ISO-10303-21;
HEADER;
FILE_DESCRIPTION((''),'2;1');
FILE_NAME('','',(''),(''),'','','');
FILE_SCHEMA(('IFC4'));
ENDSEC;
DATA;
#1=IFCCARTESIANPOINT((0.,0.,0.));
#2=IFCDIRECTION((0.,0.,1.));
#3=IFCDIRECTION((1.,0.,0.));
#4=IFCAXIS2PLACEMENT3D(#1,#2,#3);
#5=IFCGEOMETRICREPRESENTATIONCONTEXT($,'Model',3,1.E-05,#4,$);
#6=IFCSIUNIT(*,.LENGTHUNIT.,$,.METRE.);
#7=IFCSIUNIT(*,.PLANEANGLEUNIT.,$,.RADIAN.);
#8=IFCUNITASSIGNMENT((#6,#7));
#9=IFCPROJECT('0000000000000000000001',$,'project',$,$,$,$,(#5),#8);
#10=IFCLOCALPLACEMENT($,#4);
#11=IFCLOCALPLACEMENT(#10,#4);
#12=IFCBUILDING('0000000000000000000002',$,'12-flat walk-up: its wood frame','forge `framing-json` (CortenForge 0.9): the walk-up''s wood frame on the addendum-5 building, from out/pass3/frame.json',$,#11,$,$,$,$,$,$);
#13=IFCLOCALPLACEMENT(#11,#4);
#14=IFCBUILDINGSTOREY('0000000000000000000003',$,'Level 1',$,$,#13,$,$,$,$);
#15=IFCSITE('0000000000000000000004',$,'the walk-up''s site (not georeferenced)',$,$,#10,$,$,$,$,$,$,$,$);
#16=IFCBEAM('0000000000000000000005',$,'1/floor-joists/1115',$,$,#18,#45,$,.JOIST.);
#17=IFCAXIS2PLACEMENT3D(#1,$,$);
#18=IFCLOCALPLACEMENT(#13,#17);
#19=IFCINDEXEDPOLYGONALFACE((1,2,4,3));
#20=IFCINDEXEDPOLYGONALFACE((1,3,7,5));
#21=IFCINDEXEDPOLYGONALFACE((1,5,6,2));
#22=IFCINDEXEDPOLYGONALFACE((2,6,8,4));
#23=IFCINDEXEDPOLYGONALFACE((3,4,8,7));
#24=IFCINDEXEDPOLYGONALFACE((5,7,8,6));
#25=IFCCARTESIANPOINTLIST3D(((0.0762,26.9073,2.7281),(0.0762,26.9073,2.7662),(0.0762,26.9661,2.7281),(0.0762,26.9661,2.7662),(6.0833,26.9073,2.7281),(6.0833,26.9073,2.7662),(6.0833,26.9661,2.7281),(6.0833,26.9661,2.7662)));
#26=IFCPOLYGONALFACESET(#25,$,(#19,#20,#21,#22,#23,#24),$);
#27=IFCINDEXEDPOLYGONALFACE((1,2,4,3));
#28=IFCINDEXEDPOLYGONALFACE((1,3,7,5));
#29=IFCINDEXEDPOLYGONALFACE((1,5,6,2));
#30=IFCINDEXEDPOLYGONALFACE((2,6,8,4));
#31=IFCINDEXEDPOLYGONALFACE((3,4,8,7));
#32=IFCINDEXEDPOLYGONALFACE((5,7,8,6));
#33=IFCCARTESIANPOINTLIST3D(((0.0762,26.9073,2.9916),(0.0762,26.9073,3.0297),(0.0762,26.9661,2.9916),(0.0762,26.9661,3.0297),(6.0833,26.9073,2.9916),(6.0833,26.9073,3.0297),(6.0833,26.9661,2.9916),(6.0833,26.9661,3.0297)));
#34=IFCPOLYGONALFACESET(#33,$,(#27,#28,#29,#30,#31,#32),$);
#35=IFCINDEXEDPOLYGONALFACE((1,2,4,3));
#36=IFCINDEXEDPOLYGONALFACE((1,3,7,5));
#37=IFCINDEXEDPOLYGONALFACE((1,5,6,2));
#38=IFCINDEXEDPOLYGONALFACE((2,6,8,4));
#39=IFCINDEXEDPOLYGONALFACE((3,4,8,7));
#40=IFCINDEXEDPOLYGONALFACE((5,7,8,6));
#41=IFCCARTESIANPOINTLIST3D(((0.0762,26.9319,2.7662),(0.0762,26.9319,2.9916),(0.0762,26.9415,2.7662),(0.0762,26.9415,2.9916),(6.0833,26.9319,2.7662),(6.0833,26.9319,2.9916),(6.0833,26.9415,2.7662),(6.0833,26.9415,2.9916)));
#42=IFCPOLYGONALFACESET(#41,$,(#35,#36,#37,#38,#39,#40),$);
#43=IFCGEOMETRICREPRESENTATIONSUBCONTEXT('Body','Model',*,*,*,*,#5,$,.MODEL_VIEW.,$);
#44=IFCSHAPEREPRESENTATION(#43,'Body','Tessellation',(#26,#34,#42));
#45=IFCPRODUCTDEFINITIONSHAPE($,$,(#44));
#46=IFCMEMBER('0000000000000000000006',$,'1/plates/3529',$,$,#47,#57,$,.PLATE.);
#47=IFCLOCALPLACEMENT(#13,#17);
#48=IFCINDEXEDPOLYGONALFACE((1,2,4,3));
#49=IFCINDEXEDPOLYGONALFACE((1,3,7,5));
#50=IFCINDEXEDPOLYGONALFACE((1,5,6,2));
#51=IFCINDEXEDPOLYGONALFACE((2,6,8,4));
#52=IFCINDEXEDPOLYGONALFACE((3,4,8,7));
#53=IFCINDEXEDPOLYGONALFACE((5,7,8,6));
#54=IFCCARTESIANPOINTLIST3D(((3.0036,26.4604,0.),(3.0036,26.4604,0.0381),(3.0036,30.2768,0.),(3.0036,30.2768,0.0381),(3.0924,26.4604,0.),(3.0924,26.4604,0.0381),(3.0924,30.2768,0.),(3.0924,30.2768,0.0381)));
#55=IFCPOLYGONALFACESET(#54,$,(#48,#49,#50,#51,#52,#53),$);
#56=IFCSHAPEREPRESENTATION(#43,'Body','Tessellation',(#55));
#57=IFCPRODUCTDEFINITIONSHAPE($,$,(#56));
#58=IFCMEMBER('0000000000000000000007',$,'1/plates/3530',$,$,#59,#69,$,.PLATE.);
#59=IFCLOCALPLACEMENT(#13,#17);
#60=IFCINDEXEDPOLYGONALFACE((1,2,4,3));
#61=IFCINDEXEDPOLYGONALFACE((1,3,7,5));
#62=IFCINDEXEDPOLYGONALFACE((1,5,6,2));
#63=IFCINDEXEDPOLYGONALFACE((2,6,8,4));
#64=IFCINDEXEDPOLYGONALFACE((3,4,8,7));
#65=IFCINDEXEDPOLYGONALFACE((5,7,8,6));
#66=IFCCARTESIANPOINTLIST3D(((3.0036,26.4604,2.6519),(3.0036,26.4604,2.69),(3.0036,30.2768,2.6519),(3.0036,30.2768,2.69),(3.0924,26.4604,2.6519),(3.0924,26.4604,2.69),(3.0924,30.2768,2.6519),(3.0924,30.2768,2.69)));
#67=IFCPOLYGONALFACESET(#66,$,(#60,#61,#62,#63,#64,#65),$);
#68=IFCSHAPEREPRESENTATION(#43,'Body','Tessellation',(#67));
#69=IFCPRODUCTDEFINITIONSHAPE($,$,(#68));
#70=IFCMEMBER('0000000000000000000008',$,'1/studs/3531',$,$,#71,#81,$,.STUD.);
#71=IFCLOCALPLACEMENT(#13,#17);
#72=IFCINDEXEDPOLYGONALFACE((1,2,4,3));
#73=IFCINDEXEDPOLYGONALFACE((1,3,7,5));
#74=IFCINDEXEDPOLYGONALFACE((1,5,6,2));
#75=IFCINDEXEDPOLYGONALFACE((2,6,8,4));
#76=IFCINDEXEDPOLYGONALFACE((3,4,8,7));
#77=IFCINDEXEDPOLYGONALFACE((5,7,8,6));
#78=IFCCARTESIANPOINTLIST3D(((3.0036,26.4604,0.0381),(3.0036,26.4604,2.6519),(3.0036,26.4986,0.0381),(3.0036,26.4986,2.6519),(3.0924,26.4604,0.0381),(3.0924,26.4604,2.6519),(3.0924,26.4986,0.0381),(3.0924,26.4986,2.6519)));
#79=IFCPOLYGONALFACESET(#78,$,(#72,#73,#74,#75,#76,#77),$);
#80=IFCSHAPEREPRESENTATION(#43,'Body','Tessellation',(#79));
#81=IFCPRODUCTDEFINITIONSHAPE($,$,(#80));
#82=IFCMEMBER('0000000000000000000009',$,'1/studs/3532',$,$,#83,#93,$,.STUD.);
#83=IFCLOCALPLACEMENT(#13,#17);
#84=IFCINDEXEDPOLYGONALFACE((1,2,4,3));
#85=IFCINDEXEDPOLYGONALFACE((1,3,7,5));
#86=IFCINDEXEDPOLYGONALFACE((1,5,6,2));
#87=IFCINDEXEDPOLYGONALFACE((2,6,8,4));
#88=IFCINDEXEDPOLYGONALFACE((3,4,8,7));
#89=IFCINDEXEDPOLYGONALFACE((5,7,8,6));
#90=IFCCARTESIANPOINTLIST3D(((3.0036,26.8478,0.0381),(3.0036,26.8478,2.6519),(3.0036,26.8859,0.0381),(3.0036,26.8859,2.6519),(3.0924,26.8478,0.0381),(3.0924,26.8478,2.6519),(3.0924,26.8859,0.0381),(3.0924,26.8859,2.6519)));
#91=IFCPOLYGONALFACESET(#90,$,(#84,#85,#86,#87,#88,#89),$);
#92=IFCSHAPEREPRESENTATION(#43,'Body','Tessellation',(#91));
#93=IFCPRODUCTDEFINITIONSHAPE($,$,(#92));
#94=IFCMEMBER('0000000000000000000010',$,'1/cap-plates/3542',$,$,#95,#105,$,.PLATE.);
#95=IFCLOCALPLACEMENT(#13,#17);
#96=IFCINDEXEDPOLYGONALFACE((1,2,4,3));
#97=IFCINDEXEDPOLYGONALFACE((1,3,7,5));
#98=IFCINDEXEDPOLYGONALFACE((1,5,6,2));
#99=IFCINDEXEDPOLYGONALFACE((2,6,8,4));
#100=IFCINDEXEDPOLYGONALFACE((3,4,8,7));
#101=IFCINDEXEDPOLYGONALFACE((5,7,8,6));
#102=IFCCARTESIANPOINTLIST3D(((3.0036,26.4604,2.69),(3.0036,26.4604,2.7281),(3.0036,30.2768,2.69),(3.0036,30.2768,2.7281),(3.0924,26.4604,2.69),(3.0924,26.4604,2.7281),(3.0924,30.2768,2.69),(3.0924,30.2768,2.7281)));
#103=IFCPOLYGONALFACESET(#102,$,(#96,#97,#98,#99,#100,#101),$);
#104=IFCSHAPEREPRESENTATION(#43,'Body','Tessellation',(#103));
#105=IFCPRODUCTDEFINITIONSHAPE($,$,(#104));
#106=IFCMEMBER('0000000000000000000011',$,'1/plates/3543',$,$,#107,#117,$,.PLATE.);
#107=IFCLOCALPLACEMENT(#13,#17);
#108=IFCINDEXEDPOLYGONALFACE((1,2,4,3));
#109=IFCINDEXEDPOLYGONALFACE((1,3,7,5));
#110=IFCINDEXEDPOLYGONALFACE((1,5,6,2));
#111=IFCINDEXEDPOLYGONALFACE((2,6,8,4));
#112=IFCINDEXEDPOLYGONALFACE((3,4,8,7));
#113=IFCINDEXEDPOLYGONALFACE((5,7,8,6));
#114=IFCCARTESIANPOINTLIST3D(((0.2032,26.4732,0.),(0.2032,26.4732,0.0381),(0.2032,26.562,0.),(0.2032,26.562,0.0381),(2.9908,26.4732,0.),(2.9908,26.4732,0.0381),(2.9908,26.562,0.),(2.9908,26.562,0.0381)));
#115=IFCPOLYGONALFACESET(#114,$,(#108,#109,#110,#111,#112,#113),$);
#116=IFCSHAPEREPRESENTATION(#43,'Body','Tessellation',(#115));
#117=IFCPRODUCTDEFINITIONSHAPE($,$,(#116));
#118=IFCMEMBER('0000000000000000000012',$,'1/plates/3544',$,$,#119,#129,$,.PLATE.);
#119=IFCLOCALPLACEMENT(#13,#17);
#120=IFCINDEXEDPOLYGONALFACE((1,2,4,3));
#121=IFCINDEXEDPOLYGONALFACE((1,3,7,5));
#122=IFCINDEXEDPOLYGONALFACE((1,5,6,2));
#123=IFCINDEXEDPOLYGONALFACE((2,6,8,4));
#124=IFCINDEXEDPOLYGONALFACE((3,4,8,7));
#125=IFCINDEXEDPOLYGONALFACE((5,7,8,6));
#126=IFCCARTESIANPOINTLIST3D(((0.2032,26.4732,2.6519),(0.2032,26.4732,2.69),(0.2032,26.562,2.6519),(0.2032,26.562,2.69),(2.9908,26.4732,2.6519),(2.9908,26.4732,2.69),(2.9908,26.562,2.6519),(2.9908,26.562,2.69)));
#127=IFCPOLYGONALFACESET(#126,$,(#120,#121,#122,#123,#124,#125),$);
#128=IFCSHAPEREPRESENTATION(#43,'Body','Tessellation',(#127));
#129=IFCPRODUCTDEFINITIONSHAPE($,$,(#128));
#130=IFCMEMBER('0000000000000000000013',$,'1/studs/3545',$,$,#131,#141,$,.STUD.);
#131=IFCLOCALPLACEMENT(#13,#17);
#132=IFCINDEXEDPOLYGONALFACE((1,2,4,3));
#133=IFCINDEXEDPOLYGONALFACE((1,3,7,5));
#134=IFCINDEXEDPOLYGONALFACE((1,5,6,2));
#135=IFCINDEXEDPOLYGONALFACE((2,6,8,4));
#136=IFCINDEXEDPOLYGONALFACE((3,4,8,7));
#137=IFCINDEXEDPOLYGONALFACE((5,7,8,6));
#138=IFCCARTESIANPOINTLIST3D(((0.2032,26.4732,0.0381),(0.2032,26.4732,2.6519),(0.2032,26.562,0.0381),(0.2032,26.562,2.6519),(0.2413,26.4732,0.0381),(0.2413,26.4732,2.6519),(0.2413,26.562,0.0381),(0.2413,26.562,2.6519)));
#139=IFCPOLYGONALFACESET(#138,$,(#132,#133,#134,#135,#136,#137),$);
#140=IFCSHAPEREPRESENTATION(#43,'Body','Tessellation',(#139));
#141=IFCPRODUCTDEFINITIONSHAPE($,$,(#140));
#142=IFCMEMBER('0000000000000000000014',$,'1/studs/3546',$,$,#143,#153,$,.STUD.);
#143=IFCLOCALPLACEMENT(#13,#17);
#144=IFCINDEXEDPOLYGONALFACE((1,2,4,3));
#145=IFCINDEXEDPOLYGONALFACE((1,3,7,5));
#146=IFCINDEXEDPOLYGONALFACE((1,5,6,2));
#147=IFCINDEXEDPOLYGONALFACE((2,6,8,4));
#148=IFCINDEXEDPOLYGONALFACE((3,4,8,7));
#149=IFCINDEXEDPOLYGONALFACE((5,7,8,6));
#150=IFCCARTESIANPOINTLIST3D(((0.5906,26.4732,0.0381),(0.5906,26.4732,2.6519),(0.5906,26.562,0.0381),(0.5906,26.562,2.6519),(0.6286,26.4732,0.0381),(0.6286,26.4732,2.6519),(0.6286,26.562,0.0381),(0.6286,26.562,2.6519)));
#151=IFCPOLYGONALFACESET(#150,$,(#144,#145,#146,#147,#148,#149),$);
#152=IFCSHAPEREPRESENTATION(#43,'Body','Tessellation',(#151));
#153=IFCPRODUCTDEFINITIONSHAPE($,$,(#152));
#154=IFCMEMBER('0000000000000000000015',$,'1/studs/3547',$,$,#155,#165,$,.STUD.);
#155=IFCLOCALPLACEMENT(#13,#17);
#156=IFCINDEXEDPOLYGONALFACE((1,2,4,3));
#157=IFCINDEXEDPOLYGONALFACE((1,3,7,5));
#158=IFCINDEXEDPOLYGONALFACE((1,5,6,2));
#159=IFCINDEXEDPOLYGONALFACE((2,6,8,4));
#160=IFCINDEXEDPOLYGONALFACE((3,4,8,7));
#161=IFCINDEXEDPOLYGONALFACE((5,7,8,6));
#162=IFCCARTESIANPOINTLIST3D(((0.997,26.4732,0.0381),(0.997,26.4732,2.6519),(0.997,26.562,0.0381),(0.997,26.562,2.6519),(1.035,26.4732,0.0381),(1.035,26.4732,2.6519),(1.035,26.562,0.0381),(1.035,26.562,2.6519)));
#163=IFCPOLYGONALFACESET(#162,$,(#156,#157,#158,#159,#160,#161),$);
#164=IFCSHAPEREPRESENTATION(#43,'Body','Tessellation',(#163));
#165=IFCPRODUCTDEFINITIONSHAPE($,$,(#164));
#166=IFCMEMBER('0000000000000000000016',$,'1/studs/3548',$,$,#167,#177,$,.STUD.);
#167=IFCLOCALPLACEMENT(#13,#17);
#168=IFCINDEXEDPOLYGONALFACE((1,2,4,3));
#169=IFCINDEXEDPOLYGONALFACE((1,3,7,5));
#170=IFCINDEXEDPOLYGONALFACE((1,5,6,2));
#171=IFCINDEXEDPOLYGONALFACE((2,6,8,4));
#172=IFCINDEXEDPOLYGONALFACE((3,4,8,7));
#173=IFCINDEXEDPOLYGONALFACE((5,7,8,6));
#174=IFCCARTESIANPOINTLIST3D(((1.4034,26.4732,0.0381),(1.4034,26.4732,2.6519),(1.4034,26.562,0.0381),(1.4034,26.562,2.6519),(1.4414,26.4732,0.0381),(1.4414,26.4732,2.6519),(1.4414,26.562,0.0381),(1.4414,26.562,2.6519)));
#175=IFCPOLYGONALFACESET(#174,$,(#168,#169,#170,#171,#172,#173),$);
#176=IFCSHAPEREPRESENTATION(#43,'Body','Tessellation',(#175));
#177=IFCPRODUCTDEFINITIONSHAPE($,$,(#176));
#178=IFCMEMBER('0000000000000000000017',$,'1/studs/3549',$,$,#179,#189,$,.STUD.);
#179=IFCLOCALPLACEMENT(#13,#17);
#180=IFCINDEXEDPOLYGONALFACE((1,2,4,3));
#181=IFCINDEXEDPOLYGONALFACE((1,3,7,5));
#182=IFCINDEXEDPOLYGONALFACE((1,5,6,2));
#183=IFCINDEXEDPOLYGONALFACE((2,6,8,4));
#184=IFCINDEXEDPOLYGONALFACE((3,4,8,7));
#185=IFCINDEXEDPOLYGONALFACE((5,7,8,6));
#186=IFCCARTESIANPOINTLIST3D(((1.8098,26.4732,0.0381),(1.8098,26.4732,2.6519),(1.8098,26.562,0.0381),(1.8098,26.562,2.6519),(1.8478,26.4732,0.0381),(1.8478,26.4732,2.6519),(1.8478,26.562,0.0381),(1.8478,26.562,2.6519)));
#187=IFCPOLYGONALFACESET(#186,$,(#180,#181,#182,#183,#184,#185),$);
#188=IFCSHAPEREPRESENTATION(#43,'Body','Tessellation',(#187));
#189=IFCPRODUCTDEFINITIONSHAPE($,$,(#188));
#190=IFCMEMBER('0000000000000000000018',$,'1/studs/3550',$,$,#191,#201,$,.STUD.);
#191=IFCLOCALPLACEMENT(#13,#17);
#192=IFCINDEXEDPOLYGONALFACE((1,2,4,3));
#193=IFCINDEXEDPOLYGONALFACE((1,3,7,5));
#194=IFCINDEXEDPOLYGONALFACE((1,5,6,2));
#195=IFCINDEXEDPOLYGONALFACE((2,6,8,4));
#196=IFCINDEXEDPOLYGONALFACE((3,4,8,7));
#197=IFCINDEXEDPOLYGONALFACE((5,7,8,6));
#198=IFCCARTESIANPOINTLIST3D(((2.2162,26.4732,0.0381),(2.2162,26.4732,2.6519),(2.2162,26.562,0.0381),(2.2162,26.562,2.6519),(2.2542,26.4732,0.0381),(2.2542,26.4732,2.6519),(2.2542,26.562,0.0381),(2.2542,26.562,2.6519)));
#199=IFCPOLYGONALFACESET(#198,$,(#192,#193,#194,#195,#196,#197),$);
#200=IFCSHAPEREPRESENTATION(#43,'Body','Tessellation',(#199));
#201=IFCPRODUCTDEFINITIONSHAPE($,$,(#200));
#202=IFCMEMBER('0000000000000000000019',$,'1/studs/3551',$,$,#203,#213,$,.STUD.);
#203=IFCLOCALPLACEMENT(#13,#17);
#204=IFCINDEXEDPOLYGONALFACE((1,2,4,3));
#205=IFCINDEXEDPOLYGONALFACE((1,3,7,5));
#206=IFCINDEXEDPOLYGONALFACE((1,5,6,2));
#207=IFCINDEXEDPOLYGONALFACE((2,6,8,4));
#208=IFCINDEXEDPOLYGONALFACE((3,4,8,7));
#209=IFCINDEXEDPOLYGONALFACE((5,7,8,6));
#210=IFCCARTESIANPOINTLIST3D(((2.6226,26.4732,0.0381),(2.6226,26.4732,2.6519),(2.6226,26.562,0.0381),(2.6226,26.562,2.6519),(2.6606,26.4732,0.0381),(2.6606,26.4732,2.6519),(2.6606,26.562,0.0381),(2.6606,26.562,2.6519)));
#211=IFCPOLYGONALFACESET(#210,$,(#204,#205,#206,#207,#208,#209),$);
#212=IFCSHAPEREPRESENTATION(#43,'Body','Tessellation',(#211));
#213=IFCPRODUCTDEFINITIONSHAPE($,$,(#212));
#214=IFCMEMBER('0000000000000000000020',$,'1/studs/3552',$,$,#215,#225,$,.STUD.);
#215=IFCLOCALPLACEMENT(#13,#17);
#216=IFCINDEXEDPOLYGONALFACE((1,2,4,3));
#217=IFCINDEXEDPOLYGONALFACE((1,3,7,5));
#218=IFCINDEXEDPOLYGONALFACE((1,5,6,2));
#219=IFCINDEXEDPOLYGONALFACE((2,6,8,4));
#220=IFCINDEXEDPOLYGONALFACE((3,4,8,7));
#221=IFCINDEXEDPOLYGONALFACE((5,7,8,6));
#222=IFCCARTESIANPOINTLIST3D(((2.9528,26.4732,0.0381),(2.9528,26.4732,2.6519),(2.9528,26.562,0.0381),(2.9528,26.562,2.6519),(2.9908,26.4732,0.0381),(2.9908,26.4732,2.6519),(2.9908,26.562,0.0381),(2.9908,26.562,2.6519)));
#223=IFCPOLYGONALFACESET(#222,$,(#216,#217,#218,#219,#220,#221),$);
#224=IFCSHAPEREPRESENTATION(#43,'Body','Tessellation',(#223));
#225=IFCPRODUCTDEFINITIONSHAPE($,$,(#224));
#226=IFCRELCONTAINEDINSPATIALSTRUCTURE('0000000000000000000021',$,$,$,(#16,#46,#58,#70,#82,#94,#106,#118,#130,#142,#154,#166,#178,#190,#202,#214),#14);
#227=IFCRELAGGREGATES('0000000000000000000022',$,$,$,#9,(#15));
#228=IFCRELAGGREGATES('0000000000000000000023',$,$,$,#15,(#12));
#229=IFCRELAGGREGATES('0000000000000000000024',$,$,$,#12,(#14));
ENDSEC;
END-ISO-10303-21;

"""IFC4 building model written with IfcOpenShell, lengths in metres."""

from ifc_helpers import new_model, si_unit, frame, frame_2d, origin, origin_with_axes, place, context, subcontext, project, spatial, rectangle, extrude, element, save


model = new_model("IFC4")

# Units and contexts
model_context = context("Model", 3, precision=1e-05, world=origin_with_axes())
body_context = subcontext(model_context, "Body", "Model", "MODEL_VIEW")
ifc_project = project(units=[si_unit("LENGTHUNIT", "METRE"), si_unit("PLANEANGLEUNIT", "RADIAN")], contexts=[model_context])

# Site, building, storey
site_placement = place(None, origin_with_axes())
site = spatial("IfcSite", under=ifc_project, at=site_placement, Name="the walk-up's site (not georeferenced)")
building_placement = place(site_placement, origin_with_axes())
building = spatial("IfcBuilding", under=site, at=building_placement, Name="12-flat walk-up: its wood frame", Description="forge `framing-json` (CortenForge 0.9): the walk-up's wood frame on the addendum-5 building, from out/pass3/frame.json")
storey_placement = place(building_placement, origin_with_axes())
storey = spatial("IfcBuildingStorey", under=building, at=storey_placement, Name="Level 1")

# Beam
beam_1_placement = place(storey_placement, frame((0.0762, 26.9073, 2.7281), z_axis=(0.0, 0.0, 1.0), x_axis=(1.0, 0.0, 0.0)))
element("IfcBeam", 1, at=beam_1_placement, inside=storey, Name="1/floor-joists/1115", PredefinedType="JOIST", context=body_context, shape_type="SweptSolid", body=[
    extrude(rectangle(XDim=6.0071, YDim=0.0587, at=frame_2d((3.0036, 0.0294))), origin(), (0.0, 0.0, 1.0), 0.0381),
    extrude(rectangle(XDim=6.0071, YDim=0.0587, at=frame_2d((3.0036, 0.0294))), frame((0.0, 0.0, 0.2635)), (0.0, 0.0, 1.0), 0.0381),
    extrude(rectangle(XDim=6.0071, YDim=0.0095, at=frame_2d((3.0036, 0.0048))), frame((0.0, 0.0246, 0.0381)), (0.0, 0.0, 1.0), 0.2254),
])

# Members
member_1_placement = place(storey_placement, frame((3.0036, 26.4605, 0.0), z_axis=(0.0, 0.0, 1.0), x_axis=(1.0, 0.0, 0.0)))
element("IfcMember", 2, at=member_1_placement, inside=storey, Name="1/plates/3529", PredefinedType="PLATE", context=body_context, shape_type="SweptSolid", body=[
    extrude(rectangle(XDim=0.0889, YDim=3.8163, at=frame_2d((0.0444, 1.9082))), origin(), (0.0, 0.0, 1.0), 0.0381),
])
member_2_placement = place(storey_placement, frame((3.0036, 26.4605, 2.6519), z_axis=(0.0, 0.0, 1.0), x_axis=(1.0, 0.0, 0.0)))
element("IfcMember", 3, at=member_2_placement, inside=storey, Name="1/plates/3530", PredefinedType="PLATE", context=body_context, shape_type="SweptSolid", body=[
    extrude(rectangle(XDim=0.0889, YDim=3.8163, at=frame_2d((0.0444, 1.9082))), origin(), (0.0, 0.0, 1.0), 0.0381),
])
for number, where, z_axis, x_axis, name in (
    (4, (3.0036, 26.4605, 0.0381), (0.0, 0.0, 1.0), (1.0, 0.0, 0.0), "1/studs/3531"),
    (5, (3.0036, 26.8478, 0.0381), (0.0, 0.0, 1.0), (1.0, 0.0, 0.0), "1/studs/3532"),
):
    element("IfcMember", number, at=place(storey_placement, frame(where, z_axis=z_axis, x_axis=x_axis)), inside=storey, Name=name, PredefinedType="STUD", context=body_context, shape_type="SweptSolid", body=[
        extrude(rectangle(XDim=0.0889, YDim=0.0381, at=frame_2d((0.0444, 0.0191))), origin(), (0.0, 0.0, 1.0), 2.6138),
    ])
member_3_placement = place(storey_placement, frame((3.0036, 26.4605, 2.69), z_axis=(0.0, 0.0, 1.0), x_axis=(1.0, 0.0, 0.0)))
element("IfcMember", 6, at=member_3_placement, inside=storey, Name="1/cap-plates/3542", PredefinedType="PLATE", context=body_context, shape_type="SweptSolid", body=[
    extrude(rectangle(XDim=0.0889, YDim=3.8163, at=frame_2d((0.0444, 1.9082))), origin(), (0.0, 0.0, 1.0), 0.0381),
])
member_4_placement = place(storey_placement, frame((0.2032, 26.4732, 0.0), z_axis=(0.0, 0.0, 1.0), x_axis=(1.0, 0.0, 0.0)))
element("IfcMember", 7, at=member_4_placement, inside=storey, Name="1/plates/3543", PredefinedType="PLATE", context=body_context, shape_type="SweptSolid", body=[
    extrude(rectangle(XDim=2.7877, YDim=0.0889, at=frame_2d((1.3938, 0.0444))), origin(), (0.0, 0.0, 1.0), 0.0381),
])
member_5_placement = place(storey_placement, frame((0.2032, 26.4732, 2.6519), z_axis=(0.0, 0.0, 1.0), x_axis=(1.0, 0.0, 0.0)))
element("IfcMember", 8, at=member_5_placement, inside=storey, Name="1/plates/3544", PredefinedType="PLATE", context=body_context, shape_type="SweptSolid", body=[
    extrude(rectangle(XDim=2.7877, YDim=0.0889, at=frame_2d((1.3938, 0.0444))), origin(), (0.0, 0.0, 1.0), 0.0381),
])
member_6_placement = place(storey_placement, frame((0.2032, 26.4732, 0.0381), z_axis=(0.0, 0.0, 1.0), x_axis=(1.0, 0.0, 0.0)))
element("IfcMember", 9, at=member_6_placement, inside=storey, Name="1/studs/3545", PredefinedType="STUD", context=body_context, shape_type="SweptSolid", body=[
    extrude(rectangle(XDim=0.0381, YDim=0.0889, at=frame_2d((0.019, 0.0444))), origin(), (0.0, 0.0, 1.0), 2.6138),
])
for number, where, z_axis, x_axis, name in (
    (10, (0.5906, 26.4732, 0.0381), (0.0, 0.0, 1.0), (1.0, 0.0, 0.0), "1/studs/3546"),
    (11, (0.997, 26.4732, 0.0381), (0.0, 0.0, 1.0), (1.0, 0.0, 0.0), "1/studs/3547"),
):
    element("IfcMember", number, at=place(storey_placement, frame(where, z_axis=z_axis, x_axis=x_axis)), inside=storey, Name=name, PredefinedType="STUD", context=body_context, shape_type="SweptSolid", body=[
        extrude(rectangle(XDim=0.0381, YDim=0.0889, at=frame_2d((0.0191, 0.0444))), origin(), (0.0, 0.0, 1.0), 2.6138),
    ])
member_7_placement = place(storey_placement, frame((1.4034, 26.4732, 0.0381), z_axis=(0.0, 0.0, 1.0), x_axis=(1.0, 0.0, 0.0)))
element("IfcMember", 12, at=member_7_placement, inside=storey, Name="1/studs/3548", PredefinedType="STUD", context=body_context, shape_type="SweptSolid", body=[
    extrude(rectangle(XDim=0.0381, YDim=0.0889, at=frame_2d((0.019, 0.0444))), origin(), (0.0, 0.0, 1.0), 2.6138),
])
for number, where, z_axis, x_axis, name in (
    (13, (1.8097, 26.4732, 0.0381), (0.0, 0.0, 1.0), (1.0, 0.0, 0.0), "1/studs/3549"),
    (14, (2.2161, 26.4732, 0.0381), (0.0, 0.0, 1.0), (1.0, 0.0, 0.0), "1/studs/3550"),
    (15, (2.6225, 26.4732, 0.0381), (0.0, 0.0, 1.0), (1.0, 0.0, 0.0), "1/studs/3551"),
    (16, (2.9527, 26.4732, 0.0381), (0.0, 0.0, 1.0), (1.0, 0.0, 0.0), "1/studs/3552"),
):
    element("IfcMember", number, at=place(storey_placement, frame(where, z_axis=z_axis, x_axis=x_axis)), inside=storey, Name=name, PredefinedType="STUD", context=body_context, shape_type="SweptSolid", body=[
        extrude(rectangle(XDim=0.0381, YDim=0.0889, at=frame_2d((0.0191, 0.0444))), origin(), (0.0, 0.0, 1.0), 2.6138),
    ])

save(model, "model.ifc")
